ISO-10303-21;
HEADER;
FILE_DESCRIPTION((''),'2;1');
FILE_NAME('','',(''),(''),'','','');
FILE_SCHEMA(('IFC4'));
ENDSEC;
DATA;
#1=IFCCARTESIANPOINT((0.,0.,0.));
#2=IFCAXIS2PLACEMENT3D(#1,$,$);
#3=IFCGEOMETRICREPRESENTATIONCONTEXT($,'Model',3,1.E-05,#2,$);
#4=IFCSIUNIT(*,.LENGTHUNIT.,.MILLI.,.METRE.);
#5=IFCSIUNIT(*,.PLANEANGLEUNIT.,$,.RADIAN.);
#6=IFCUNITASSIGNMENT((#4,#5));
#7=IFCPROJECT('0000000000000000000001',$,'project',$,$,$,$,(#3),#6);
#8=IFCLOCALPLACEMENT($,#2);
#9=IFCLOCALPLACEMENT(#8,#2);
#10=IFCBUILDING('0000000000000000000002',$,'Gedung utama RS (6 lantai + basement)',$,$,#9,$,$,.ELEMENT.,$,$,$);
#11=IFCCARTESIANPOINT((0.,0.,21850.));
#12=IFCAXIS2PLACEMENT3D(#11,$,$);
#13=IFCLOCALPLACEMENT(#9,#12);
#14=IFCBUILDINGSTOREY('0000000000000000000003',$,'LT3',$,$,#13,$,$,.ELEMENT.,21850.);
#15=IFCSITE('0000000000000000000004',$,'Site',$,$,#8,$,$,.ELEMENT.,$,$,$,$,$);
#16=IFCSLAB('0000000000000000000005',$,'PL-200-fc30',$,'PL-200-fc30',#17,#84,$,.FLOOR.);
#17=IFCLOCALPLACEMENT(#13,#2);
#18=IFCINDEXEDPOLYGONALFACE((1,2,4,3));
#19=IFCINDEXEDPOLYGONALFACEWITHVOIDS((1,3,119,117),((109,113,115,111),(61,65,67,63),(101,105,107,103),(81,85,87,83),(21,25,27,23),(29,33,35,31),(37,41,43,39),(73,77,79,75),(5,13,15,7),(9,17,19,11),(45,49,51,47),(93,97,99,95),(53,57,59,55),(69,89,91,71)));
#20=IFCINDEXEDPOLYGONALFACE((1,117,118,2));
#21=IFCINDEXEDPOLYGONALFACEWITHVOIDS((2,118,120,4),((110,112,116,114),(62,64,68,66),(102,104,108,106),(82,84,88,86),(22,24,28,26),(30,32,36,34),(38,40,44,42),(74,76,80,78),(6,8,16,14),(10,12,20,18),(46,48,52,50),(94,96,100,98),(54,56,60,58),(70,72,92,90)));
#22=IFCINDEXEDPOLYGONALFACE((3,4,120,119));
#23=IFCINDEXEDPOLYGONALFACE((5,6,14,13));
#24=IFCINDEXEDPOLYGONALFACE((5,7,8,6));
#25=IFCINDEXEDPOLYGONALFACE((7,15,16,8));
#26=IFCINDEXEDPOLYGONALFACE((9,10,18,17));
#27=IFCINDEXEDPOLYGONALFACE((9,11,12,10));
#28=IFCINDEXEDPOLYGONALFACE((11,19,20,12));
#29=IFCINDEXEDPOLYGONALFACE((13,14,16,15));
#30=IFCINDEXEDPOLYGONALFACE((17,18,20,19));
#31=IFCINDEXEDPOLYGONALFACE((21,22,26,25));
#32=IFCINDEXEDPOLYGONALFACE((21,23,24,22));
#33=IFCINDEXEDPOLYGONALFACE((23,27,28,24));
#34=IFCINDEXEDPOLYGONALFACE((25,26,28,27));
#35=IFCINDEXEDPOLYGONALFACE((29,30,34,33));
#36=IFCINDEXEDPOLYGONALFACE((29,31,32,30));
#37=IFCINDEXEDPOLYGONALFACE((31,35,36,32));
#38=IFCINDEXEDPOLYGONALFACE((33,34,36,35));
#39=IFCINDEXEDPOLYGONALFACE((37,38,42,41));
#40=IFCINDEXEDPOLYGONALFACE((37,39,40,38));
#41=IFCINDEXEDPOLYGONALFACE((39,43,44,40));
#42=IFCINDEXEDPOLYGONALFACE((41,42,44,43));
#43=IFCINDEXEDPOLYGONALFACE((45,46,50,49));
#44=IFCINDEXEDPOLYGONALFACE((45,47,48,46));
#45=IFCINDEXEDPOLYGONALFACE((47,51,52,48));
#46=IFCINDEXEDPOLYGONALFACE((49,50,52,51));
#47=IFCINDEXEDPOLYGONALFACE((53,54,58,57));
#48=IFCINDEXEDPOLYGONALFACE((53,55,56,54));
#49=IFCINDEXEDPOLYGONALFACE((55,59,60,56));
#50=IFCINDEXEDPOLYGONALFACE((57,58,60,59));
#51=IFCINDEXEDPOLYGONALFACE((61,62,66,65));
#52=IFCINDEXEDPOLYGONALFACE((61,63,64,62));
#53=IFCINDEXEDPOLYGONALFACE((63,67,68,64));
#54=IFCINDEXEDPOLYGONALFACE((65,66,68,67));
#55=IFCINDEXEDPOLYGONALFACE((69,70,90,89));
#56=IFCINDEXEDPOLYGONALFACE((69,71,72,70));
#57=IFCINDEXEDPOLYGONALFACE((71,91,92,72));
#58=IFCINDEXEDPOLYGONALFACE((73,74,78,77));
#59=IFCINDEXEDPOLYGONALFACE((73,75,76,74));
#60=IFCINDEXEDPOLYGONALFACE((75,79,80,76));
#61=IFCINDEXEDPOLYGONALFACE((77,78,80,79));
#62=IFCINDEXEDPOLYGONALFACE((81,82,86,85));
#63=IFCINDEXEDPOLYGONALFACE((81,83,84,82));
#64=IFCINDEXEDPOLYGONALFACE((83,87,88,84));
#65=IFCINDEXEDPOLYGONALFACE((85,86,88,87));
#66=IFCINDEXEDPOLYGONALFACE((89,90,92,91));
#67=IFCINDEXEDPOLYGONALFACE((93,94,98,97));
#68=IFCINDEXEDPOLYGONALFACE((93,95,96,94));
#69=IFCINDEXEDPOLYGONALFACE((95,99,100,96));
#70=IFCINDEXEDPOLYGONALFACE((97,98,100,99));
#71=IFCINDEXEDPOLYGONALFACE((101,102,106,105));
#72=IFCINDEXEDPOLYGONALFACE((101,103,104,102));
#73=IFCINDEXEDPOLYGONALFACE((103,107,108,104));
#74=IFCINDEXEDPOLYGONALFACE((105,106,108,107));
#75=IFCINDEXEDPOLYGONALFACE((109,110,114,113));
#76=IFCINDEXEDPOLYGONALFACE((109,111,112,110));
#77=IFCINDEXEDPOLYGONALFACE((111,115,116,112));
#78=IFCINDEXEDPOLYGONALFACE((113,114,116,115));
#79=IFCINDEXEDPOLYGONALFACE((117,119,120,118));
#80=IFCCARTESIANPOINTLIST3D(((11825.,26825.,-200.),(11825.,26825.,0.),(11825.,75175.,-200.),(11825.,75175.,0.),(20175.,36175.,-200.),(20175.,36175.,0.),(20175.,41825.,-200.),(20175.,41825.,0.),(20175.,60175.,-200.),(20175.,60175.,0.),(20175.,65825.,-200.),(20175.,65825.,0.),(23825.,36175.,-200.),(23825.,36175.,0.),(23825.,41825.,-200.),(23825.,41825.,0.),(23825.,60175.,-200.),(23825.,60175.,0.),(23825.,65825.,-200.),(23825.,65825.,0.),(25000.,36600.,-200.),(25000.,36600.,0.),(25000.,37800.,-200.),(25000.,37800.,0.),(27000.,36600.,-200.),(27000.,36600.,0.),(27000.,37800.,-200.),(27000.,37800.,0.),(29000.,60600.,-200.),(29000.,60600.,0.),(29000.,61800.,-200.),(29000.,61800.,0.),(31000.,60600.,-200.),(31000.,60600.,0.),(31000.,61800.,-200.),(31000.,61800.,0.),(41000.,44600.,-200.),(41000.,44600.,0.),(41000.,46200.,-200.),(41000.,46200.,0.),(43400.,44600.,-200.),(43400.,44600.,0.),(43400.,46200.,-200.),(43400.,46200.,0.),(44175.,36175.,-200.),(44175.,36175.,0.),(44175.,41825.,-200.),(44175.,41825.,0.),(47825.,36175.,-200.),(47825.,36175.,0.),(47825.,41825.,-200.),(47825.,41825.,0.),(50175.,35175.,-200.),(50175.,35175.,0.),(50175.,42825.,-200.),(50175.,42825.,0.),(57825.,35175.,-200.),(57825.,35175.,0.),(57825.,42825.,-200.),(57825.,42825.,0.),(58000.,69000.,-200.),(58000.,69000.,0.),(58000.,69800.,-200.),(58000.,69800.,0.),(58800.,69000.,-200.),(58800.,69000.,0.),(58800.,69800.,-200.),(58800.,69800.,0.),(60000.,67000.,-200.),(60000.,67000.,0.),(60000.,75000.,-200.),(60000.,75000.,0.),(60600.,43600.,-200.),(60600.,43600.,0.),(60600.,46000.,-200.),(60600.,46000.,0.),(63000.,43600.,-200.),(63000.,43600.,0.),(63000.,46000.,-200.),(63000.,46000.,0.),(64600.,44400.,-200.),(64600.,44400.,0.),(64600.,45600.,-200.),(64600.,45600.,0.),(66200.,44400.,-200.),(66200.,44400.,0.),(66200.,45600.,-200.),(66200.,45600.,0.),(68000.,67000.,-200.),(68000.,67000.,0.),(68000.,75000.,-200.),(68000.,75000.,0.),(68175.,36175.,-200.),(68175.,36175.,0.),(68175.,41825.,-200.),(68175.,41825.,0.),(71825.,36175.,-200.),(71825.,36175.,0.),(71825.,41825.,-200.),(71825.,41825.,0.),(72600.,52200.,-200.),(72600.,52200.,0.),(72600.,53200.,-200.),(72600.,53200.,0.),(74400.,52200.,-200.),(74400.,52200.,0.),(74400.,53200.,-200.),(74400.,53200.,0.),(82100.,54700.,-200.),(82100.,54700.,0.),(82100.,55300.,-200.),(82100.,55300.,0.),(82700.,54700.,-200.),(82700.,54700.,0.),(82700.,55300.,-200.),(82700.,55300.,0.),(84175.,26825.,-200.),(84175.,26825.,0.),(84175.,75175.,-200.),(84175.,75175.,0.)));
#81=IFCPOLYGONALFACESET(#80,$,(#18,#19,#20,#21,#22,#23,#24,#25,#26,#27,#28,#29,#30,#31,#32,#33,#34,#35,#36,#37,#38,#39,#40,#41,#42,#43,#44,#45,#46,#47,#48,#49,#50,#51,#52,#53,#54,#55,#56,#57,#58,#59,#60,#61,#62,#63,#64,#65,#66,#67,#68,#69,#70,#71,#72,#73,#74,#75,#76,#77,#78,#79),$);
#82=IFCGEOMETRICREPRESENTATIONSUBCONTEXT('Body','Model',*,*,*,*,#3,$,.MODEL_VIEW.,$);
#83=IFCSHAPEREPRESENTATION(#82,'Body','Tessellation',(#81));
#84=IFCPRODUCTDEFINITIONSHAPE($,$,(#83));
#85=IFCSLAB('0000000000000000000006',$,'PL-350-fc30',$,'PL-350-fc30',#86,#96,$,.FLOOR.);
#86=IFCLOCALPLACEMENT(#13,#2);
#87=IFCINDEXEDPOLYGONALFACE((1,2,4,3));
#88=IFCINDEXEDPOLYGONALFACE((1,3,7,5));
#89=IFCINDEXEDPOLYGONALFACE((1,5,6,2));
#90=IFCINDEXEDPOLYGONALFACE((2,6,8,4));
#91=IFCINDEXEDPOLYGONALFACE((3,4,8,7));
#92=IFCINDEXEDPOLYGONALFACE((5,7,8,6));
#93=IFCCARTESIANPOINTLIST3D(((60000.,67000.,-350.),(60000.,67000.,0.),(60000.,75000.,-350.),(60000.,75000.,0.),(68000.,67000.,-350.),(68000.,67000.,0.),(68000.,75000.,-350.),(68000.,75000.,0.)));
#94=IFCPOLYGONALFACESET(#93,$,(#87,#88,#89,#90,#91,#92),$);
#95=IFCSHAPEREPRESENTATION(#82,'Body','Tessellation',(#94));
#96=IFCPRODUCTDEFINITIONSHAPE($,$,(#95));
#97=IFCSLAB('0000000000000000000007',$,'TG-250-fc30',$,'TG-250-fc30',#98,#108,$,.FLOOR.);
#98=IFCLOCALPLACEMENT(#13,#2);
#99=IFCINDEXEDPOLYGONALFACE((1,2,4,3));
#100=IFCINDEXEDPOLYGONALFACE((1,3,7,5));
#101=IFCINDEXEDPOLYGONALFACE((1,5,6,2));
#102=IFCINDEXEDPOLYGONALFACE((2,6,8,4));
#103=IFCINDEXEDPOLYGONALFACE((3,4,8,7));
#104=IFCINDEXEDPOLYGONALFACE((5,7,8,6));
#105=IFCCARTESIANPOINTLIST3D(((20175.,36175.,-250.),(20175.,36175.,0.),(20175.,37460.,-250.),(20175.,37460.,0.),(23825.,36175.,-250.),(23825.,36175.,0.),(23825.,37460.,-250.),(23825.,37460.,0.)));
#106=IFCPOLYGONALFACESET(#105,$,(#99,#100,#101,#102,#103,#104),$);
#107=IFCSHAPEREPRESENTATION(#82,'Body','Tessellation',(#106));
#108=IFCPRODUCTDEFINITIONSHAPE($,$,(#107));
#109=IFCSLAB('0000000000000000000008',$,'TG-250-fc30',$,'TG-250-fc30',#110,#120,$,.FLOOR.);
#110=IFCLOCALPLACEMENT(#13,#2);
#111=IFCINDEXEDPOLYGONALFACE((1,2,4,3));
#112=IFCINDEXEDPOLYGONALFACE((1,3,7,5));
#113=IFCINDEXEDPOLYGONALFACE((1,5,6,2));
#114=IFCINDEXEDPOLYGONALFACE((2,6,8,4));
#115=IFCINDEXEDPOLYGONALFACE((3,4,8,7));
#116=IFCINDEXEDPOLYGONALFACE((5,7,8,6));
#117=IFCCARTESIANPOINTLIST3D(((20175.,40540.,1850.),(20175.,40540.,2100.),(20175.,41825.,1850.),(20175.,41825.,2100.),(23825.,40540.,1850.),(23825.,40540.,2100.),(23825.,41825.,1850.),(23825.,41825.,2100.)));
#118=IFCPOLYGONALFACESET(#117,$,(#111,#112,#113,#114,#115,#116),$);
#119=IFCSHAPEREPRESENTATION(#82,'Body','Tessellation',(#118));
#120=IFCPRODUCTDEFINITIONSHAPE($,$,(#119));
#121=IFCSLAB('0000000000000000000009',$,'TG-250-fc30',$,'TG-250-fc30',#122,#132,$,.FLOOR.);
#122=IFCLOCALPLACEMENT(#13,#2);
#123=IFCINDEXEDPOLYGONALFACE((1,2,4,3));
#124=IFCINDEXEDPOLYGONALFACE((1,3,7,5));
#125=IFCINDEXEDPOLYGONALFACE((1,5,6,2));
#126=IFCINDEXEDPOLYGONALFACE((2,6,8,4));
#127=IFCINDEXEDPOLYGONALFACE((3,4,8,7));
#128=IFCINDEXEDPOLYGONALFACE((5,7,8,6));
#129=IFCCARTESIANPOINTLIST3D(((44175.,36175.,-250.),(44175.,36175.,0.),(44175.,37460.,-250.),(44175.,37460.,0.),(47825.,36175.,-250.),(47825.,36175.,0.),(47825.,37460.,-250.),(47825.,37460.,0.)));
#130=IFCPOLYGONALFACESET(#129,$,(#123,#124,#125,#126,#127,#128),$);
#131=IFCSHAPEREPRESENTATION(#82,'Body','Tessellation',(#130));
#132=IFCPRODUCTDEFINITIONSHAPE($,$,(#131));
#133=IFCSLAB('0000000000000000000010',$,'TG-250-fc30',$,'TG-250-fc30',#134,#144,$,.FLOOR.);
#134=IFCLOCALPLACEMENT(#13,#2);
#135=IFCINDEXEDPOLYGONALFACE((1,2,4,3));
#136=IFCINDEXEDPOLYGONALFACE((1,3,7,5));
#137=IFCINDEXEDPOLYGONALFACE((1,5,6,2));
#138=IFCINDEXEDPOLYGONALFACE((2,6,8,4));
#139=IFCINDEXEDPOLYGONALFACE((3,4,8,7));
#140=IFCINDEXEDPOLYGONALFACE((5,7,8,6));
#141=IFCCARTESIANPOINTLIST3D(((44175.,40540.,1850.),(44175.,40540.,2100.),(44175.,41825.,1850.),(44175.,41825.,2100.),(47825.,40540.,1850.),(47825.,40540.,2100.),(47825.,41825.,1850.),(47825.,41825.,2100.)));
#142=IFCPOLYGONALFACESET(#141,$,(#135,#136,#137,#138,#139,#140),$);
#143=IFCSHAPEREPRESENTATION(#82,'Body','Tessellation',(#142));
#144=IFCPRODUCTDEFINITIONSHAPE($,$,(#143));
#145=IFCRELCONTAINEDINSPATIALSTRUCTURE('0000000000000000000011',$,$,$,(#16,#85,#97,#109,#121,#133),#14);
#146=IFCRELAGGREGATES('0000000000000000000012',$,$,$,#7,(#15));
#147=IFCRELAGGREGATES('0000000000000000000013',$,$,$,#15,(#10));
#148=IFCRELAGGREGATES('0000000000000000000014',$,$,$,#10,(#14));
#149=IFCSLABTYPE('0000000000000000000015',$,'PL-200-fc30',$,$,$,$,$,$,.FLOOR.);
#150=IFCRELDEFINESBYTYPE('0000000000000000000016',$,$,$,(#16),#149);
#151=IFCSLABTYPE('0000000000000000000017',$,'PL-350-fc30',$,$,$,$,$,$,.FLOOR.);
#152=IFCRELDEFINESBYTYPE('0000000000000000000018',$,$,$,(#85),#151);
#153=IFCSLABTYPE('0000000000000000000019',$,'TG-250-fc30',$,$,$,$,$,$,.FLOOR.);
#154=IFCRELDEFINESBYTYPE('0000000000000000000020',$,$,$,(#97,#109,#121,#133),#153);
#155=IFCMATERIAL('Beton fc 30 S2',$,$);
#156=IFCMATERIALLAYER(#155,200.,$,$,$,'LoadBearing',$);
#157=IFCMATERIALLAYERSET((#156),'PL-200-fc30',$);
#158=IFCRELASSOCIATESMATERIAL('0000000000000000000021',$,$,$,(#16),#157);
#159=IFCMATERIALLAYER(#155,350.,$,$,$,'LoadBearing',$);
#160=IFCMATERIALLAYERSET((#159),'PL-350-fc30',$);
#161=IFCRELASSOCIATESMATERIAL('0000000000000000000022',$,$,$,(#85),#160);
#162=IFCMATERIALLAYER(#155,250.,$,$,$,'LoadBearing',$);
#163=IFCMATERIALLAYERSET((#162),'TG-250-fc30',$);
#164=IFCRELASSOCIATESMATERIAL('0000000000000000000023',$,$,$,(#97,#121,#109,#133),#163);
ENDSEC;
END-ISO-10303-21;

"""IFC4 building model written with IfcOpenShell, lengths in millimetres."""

from ifc_helpers import new_model, si_unit, frame, origin, place, context, subcontext, project, spatial, polyline, outline, extrude, material, layer, layer_set, layer_usage, type_object, element, save


model = new_model("IFC4")

# Units and contexts
model_context = context("Model", 3, precision=1e-05, world=origin())
body_context = subcontext(model_context, "Body", "Model", "MODEL_VIEW")
ifc_project = project(units=[si_unit("LENGTHUNIT", "METRE", prefix="MILLI"), si_unit("PLANEANGLEUNIT", "RADIAN")], contexts=[model_context])

# Site, building, storey
site_placement = place(None, origin())
site = spatial("IfcSite", under=ifc_project, at=site_placement, Name="Site", CompositionType="ELEMENT")
building_placement = place(site_placement, origin())
building = spatial("IfcBuilding", under=site, at=building_placement, Name="Gedung utama RS (6 lantai + basement)", CompositionType="ELEMENT")
storey_placement = place(building_placement, frame((0.0, 0.0, 21850.0)))
storey = spatial("IfcBuildingStorey", under=building, at=storey_placement, Name="LT3", CompositionType="ELEMENT", Elevation=21850.0)

# Shared definitions
ifc_material_1 = material(Name="Beton fc 30 S2")

# Slab, openings
ifc_layer_1 = layer(ifc_material_1, 200.0, Category="LoadBearing")
ifc_layer_set_1 = layer_set([ifc_layer_1], Name="PL-200-fc30")
ifc_layer_usage_1 = layer_usage(ifc_layer_set_1, "AXIS3", "NEGATIVE", 0.0)
slab_type_1 = type_object("IfcSlabType", Name="PL-200-fc30", PredefinedType="FLOOR")
slab_1_placement = place(storey_placement, origin())
slab_1 = element("IfcSlab", 1, at=slab_1_placement, inside=storey, type_object=slab_type_1, material=ifc_layer_usage_1, Name="PL-200-fc30", ObjectType="PL-200-fc30", PredefinedType="FLOOR", context=body_context, shape_type="SweptSolid", body=[
    extrude(outline(polyline([(84175.0, 26825.0), (84175.0, 75175.0), (11825.0, 75175.0), (11825.0, 26825.0), (84175.0, 26825.0)]), holes=[polyline([(23825.0, 36175.0), (23825.0, 41825.0), (20175.0, 41825.0), (20175.0, 36175.0), (23825.0, 36175.0)]), polyline([(47825.0, 36175.0), (47825.0, 41825.0), (44175.0, 41825.0), (44175.0, 36175.0), (47825.0, 36175.0)]), polyline([(71825.0, 36175.0), (71825.0, 41825.0), (68175.0, 41825.0), (68175.0, 36175.0), (71825.0, 36175.0)]), polyline([(23825.0, 60175.0), (23825.0, 65825.0), (20175.0, 65825.0), (20175.0, 60175.0), (23825.0, 60175.0)]), polyline([(68000.0, 67000.0), (68000.0, 75000.0), (60000.0, 75000.0), (60000.0, 67000.0), (68000.0, 67000.0)])]), frame((0.0, 0.0, -200.0)), (0.0, 0.0, 1.0), 200.0),
])
opening_1_placement = place(slab_1_placement, frame((0.0, 0.0, -8900.0)))
element("IfcOpeningElement", 2, at=opening_1_placement, cuts=slab_1, PredefinedType="OPENING", context=body_context, shape_type="SweptSolid", body=[
    extrude(outline(polyline([(27000.0, 36600.0), (27000.0, 37800.0), (25000.0, 37800.0), (25000.0, 36600.0), (27000.0, 36600.0)])), origin(), (0.0, 0.0, 1.0), 25800.0),
])
opening_2_placement = place(slab_1_placement, frame((0.0, 0.0, -8900.0)))
element("IfcOpeningElement", 3, at=opening_2_placement, cuts=slab_1, PredefinedType="OPENING", context=body_context, shape_type="SweptSolid", body=[
    extrude(outline(polyline([(43400.0, 44600.0), (43400.0, 46200.0), (41000.0, 46200.0), (41000.0, 44600.0), (43400.0, 44600.0)])), origin(), (0.0, 0.0, 1.0), 25800.0),
])
opening_3_placement = place(slab_1_placement, frame((0.0, 0.0, -8900.0)))
element("IfcOpeningElement", 4, at=opening_3_placement, cuts=slab_1, PredefinedType="OPENING", context=body_context, shape_type="SweptSolid", body=[
    extrude(outline(polyline([(66200.0, 44400.0), (66200.0, 45600.0), (64600.0, 45600.0), (64600.0, 44400.0), (66200.0, 44400.0)])), origin(), (0.0, 0.0, 1.0), 25800.0),
])
opening_4_placement = place(slab_1_placement, frame((0.0, 0.0, -4400.0)))
element("IfcOpeningElement", 5, at=opening_4_placement, cuts=slab_1, PredefinedType="OPENING", context=body_context, shape_type="SweptSolid", body=[
    extrude(outline(polyline([(63000.0, 43600.0), (63000.0, 46000.0), (60600.0, 46000.0), (60600.0, 43600.0), (63000.0, 43600.0)])), origin(), (0.0, 0.0, 1.0), 4500.0),
])
opening_5_placement = place(slab_1_placement, frame((0.0, 0.0, -8900.0)))
element("IfcOpeningElement", 6, at=opening_5_placement, cuts=slab_1, PredefinedType="OPENING", context=body_context, shape_type="SweptSolid", body=[
    extrude(outline(polyline([(31000.0, 60600.0), (31000.0, 61800.0), (29000.0, 61800.0), (29000.0, 60600.0), (31000.0, 60600.0)])), origin(), (0.0, 0.0, 1.0), 13200.0),
])
opening_6_placement = place(slab_1_placement, frame((0.0, 0.0, -8900.0)))
element("IfcOpeningElement", 7, at=opening_6_placement, cuts=slab_1, PredefinedType="OPENING", context=body_context, shape_type="SweptSolid", body=[
    extrude(outline(polyline([(82700.0, 54700.0), (82700.0, 55300.0), (82100.0, 55300.0), (82100.0, 54700.0), (82700.0, 54700.0)])), origin(), (0.0, 0.0, 1.0), 9000.0),
])
opening_7_placement = place(slab_1_placement, frame((0.0, 0.0, -4400.0)))
element("IfcOpeningElement", 8, at=opening_7_placement, cuts=slab_1, PredefinedType="OPENING", context=body_context, shape_type="SweptSolid", body=[
    extrude(outline(polyline([(74400.0, 52200.0), (74400.0, 53200.0), (72600.0, 53200.0), (72600.0, 52200.0), (74400.0, 52200.0)])), origin(), (0.0, 0.0, 1.0), 4500.0),
])
opening_8_placement = place(slab_1_placement, frame((0.0, 0.0, -4400.0)))
element("IfcOpeningElement", 9, at=opening_8_placement, cuts=slab_1, PredefinedType="OPENING", context=body_context, shape_type="SweptSolid", body=[
    extrude(outline(polyline([(58800.0, 69000.0), (58800.0, 69800.0), (58000.0, 69800.0), (58000.0, 69000.0), (58800.0, 69000.0)])), origin(), (0.0, 0.0, 1.0), 4500.0),
])
opening_9_placement = place(slab_1_placement, frame((0.0, 0.0, -8900.0)))
element("IfcOpeningElement", 10, at=opening_9_placement, cuts=slab_1, PredefinedType="OPENING", context=body_context, shape_type="SweptSolid", body=[
    extrude(outline(polyline([(57825.0, 35175.0), (57825.0, 42825.0), (50175.0, 42825.0), (50175.0, 35175.0), (57825.0, 35175.0)])), origin(), (0.0, 0.0, 1.0), 21600.0),
])

# Slabs
ifc_layer_2 = layer(ifc_material_1, 350.0, Category="LoadBearing")
ifc_layer_set_2 = layer_set([ifc_layer_2], Name="PL-350-fc30")
ifc_layer_usage_2 = layer_usage(ifc_layer_set_2, "AXIS3", "NEGATIVE", 0.0)
slab_type_2 = type_object("IfcSlabType", Name="PL-350-fc30", PredefinedType="FLOOR")
slab_2_placement = place(storey_placement, origin())
element("IfcSlab", 11, at=slab_2_placement, inside=storey, type_object=slab_type_2, material=ifc_layer_usage_2, Name="PL-350-fc30", ObjectType="PL-350-fc30", PredefinedType="FLOOR", context=body_context, shape_type="SweptSolid", body=[
    extrude(outline(polyline([(68000.0, 67000.0), (68000.0, 75000.0), (60000.0, 75000.0), (60000.0, 67000.0), (68000.0, 67000.0)])), frame((0.0, 0.0, -350.0)), (0.0, 0.0, 1.0), 350.0),
])
ifc_layer_3 = layer(ifc_material_1, 250.0, Category="LoadBearing")
ifc_layer_set_3 = layer_set([ifc_layer_3], Name="TG-250-fc30")
ifc_layer_usage_3 = layer_usage(ifc_layer_set_3, "AXIS3", "NEGATIVE", 0.0)
slab_type_3 = type_object("IfcSlabType", Name="TG-250-fc30", PredefinedType="FLOOR")
slab_3_placement = place(storey_placement, origin())
element("IfcSlab", 12, at=slab_3_placement, inside=storey, type_object=slab_type_3, material=ifc_layer_usage_3, Name="TG-250-fc30", ObjectType="TG-250-fc30", PredefinedType="FLOOR", context=body_context, shape_type="SweptSolid", body=[
    extrude(outline(polyline([(23825.0, 36175.0), (23825.0, 37460.0), (20175.0, 37460.0), (20175.0, 36175.0), (23825.0, 36175.0)])), frame((0.0, 0.0, -250.0)), (0.0, 0.0, 1.0), 250.0),
])
ifc_layer_usage_4 = layer_usage(ifc_layer_set_3, "AXIS3", "NEGATIVE", 2100.0)
slab_4_placement = place(storey_placement, origin())
element("IfcSlab", 13, at=slab_4_placement, inside=storey, type_object=slab_type_3, material=ifc_layer_usage_4, Name="TG-250-fc30", ObjectType="TG-250-fc30", PredefinedType="FLOOR", context=body_context, shape_type="SweptSolid", body=[
    extrude(outline(polyline([(23825.0, 40540.0), (23825.0, 41825.0), (20175.0, 41825.0), (20175.0, 40540.0), (23825.0, 40540.0)])), frame((0.0, 0.0, 1850.0)), (0.0, 0.0, 1.0), 250.0),
])
slab_5_placement = place(storey_placement, origin())
element("IfcSlab", 14, at=slab_5_placement, inside=storey, type_object=slab_type_3, material=ifc_layer_usage_3, Name="TG-250-fc30", ObjectType="TG-250-fc30", PredefinedType="FLOOR", context=body_context, shape_type="SweptSolid", body=[
    extrude(outline(polyline([(47825.0, 36175.0), (47825.0, 37460.0), (44175.0, 37460.0), (44175.0, 36175.0), (47825.0, 36175.0)])), frame((0.0, 0.0, -250.0)), (0.0, 0.0, 1.0), 250.0),
])
slab_6_placement = place(storey_placement, origin())
element("IfcSlab", 15, at=slab_6_placement, inside=storey, type_object=slab_type_3, material=ifc_layer_usage_4, Name="TG-250-fc30", ObjectType="TG-250-fc30", PredefinedType="FLOOR", context=body_context, shape_type="SweptSolid", body=[
    extrude(outline(polyline([(47825.0, 40540.0), (47825.0, 41825.0), (44175.0, 41825.0), (44175.0, 40540.0), (47825.0, 40540.0)])), frame((0.0, 0.0, 1850.0)), (0.0, 0.0, 1.0), 250.0),
])

save(model, "model.ifc")
